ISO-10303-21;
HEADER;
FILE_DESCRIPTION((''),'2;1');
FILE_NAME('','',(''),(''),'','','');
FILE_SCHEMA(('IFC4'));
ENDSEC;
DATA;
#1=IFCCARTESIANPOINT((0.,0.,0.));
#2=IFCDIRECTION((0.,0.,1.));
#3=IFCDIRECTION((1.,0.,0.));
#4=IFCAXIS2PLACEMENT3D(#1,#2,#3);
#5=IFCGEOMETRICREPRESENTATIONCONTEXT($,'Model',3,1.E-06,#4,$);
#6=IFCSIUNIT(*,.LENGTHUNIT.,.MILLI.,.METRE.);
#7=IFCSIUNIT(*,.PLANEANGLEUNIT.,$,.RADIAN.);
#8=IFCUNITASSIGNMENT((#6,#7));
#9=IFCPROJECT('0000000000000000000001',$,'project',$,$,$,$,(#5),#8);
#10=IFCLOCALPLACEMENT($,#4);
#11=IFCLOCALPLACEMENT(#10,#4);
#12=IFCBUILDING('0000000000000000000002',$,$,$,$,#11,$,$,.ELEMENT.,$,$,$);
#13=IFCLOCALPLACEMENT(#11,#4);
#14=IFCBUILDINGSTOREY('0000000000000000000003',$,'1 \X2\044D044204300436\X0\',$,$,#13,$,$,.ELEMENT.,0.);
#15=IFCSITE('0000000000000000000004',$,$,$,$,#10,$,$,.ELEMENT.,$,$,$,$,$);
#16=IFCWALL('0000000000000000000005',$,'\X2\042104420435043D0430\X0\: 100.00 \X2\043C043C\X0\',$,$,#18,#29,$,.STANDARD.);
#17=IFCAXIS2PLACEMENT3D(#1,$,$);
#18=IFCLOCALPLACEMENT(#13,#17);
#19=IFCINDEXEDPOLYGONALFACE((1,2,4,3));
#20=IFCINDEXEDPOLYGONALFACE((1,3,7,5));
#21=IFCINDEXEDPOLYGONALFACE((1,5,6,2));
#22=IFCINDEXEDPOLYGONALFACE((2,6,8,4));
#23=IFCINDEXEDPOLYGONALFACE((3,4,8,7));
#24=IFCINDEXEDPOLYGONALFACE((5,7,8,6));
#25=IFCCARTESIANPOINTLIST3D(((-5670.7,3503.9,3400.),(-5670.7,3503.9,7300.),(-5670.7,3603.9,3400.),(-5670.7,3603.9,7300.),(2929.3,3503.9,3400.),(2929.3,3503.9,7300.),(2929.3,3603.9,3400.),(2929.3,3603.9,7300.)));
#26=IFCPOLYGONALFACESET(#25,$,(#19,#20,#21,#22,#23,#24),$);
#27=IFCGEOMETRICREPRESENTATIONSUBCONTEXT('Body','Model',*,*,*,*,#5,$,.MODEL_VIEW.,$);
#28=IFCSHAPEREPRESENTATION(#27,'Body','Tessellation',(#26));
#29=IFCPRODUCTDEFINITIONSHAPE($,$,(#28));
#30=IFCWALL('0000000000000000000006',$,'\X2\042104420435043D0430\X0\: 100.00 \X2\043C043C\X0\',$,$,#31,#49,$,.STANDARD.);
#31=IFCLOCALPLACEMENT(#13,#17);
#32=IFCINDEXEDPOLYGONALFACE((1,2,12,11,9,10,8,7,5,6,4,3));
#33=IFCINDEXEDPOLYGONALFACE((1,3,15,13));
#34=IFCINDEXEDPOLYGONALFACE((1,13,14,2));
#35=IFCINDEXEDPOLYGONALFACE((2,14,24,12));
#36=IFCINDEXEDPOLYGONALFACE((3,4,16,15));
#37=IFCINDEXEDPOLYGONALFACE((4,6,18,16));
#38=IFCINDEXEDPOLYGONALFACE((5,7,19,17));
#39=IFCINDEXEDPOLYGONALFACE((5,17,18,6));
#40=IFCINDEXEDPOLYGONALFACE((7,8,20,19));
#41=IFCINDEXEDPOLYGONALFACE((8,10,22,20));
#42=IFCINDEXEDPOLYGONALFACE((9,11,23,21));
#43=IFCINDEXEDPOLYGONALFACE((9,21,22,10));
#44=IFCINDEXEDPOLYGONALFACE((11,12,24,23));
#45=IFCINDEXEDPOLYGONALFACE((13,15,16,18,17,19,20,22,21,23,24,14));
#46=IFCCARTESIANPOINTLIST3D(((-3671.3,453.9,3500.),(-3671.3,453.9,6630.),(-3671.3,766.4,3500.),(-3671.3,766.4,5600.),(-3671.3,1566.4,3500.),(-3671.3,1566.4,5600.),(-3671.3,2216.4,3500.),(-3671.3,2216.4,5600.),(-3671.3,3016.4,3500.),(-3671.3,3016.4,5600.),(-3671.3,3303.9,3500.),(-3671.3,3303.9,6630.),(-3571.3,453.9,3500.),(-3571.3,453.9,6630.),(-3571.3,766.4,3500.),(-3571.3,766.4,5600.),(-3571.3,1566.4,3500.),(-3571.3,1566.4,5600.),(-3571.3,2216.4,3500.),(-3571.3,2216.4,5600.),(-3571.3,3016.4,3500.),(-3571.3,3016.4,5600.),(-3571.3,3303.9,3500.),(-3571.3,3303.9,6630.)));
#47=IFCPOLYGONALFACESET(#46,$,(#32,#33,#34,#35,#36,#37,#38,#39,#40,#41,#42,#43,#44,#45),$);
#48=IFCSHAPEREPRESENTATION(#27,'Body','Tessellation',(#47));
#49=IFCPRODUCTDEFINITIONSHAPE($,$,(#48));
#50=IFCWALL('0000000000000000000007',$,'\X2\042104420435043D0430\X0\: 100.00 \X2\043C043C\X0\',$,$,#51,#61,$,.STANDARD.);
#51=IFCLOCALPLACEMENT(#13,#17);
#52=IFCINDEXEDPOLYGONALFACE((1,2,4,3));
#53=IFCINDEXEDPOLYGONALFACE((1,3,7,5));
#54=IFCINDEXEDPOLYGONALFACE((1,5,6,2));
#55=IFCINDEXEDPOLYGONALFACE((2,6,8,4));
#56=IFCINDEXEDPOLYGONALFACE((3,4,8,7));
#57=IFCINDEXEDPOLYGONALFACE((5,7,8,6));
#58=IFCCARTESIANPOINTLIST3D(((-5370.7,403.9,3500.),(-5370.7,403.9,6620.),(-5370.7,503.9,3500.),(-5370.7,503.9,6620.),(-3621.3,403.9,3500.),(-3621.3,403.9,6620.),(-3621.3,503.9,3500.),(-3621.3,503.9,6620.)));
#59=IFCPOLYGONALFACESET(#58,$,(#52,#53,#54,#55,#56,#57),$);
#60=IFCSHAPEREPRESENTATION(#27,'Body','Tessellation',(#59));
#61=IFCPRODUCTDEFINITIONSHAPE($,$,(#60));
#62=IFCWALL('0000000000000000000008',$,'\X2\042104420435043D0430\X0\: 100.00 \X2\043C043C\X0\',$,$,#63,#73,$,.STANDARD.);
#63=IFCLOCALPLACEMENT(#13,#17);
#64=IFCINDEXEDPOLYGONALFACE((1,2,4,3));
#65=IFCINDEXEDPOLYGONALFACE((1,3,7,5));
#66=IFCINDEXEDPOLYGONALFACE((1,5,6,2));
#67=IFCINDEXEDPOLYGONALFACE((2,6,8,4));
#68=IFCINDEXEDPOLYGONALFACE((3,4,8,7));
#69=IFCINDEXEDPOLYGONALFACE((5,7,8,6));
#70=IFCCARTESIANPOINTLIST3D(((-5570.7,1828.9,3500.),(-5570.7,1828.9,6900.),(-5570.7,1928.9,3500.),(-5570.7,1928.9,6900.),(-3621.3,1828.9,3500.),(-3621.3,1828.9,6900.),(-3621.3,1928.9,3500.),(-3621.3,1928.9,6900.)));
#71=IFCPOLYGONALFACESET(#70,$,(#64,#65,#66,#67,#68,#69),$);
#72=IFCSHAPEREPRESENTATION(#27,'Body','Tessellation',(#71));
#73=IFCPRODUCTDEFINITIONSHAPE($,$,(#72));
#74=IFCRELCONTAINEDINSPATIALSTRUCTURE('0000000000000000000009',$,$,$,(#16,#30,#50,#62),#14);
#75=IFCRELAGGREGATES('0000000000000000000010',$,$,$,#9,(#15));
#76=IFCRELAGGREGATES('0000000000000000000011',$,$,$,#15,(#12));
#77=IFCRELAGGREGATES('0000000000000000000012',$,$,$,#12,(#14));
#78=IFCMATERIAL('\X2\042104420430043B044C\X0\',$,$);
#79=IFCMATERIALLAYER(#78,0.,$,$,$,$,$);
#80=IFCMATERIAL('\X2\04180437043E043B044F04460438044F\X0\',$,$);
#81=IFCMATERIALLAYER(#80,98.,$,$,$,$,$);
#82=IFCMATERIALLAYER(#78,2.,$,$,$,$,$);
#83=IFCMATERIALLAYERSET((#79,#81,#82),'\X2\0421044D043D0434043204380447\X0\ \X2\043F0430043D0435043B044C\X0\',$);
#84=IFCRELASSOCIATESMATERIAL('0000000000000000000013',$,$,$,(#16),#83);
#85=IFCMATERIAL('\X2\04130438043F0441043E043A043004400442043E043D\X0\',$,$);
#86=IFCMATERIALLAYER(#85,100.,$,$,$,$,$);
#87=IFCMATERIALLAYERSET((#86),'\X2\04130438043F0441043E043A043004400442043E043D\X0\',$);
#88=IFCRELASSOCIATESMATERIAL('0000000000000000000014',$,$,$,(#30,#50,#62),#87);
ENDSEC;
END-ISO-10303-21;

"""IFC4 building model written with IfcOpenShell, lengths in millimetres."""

from ifc_helpers import new_model, si_unit, frame, origin_with_axes, place, context, subcontext, project, spatial, line, indexed_curve, outline, extrude, material, layer, layer_set, layer_usage, element, save


model = new_model("IFC4")

# Units and contexts
model_context = context("Model", 3, precision=1e-06, world=origin_with_axes())
body_context = subcontext(model_context, "Body", "Model", "MODEL_VIEW")
ifc_project = project(units=[si_unit("LENGTHUNIT", "METRE", prefix="MILLI"), si_unit("PLANEANGLEUNIT", "RADIAN")], contexts=[model_context])

# Site, building, storey
site_placement = place(None, origin_with_axes())
site = spatial("IfcSite", under=ifc_project, at=site_placement, CompositionType="ELEMENT")
building_placement = place(site_placement, origin_with_axes())
building = spatial("IfcBuilding", under=site, at=building_placement, CompositionType="ELEMENT")
storey_placement = place(building_placement, origin_with_axes())
storey = spatial("IfcBuildingStorey", under=building, at=storey_placement, Name="1 этаж", CompositionType="ELEMENT", Elevation=0.0)

# Wall
ifc_material_1 = material(Name="Сталь")
ifc_layer_1 = layer(ifc_material_1, 0.0)
ifc_material_2 = material(Name="Изоляция")
ifc_layer_2 = layer(ifc_material_2, 98.0)
ifc_layer_3 = layer(ifc_material_1, 2.0)
ifc_layer_set_1 = layer_set([ifc_layer_1, ifc_layer_2, ifc_layer_3], Name="Сэндвич панель")
ifc_layer_usage_1 = layer_usage(ifc_layer_set_1, "AXIS2", "NEGATIVE", 100.0)
wall_1_placement = place(storey_placement, frame((-5670.7, 3503.9, 3400.0), z_axis=(0.0, 0.0, 1.0), x_axis=(1.0, 0.0, 0.0)))
element("IfcWall", 1, at=wall_1_placement, inside=storey, material=ifc_layer_usage_1, Name="Стена: 100.00 мм", PredefinedType="STANDARD", context=body_context, shape_type="SweptSolid", body=[
    extrude(outline(indexed_curve([(0.0, 0.0), (8600.0, 0.0), (8600.0, 100.0), (0.0, 100.0)], segments=[line(1, 2), line(2, 3), line(3, 4), line(4, 1)])), origin_with_axes(), (0.0, 0.0, 1.0), 3900.0),
])

# Wall, openings
ifc_material_3 = material(Name="Гипсокартон")
ifc_layer_4 = layer(ifc_material_3, 100.0)
ifc_layer_set_2 = layer_set([ifc_layer_4], Name="Гипсокартон")
ifc_layer_usage_2 = layer_usage(ifc_layer_set_2, "AXIS2", "NEGATIVE", 50.0)
wall_2_placement = place(storey_placement, frame((-3621.3, 3303.9, 3500.0), z_axis=(0.0, 0.0, 1.0), x_axis=(0.0, -1.0, 0.0)))
wall_2 = element("IfcWall", 2, at=wall_2_placement, inside=storey, material=ifc_layer_usage_2, Name="Стена: 100.00 мм", PredefinedType="STANDARD", context=body_context, shape_type="SweptSolid", body=[
    extrude(outline(indexed_curve([(0.0, -50.0), (2850.0, -50.0), (2850.0, 50.0), (0.0, 50.0)], segments=[line(1, 2), line(2, 3), line(3, 4), line(4, 1)])), origin_with_axes(), (0.0, 0.0, 1.0), 3130.0),
])
opening_1_placement = place(wall_2_placement, frame((1087.5, 50.0, 0.0), z_axis=(0.0, 0.0, 1.0), x_axis=(-1.0, 0.0, 0.0)))
element("IfcOpeningElement", 3, at=opening_1_placement, cuts=wall_2, PredefinedType="OPENING", context=body_context, shape_type="SweptSolid", body=[
    extrude(outline(indexed_curve([(0.0, 0.0), (800.0, 0.0), (800.0, 2100.0), (0.0, 2100.0)], segments=[line(1, 2), line(2, 3), line(3, 4), line(4, 1)])), frame((0.0, -5.0, 0.0), z_axis=(0.0, -1.0, 0.0), x_axis=(1.0, 0.0, 0.0)), (0.0, 0.0, -1.0), 110.0),
])
opening_2_placement = place(wall_2_placement, frame((2537.5, 50.0, 0.0), z_axis=(0.0, 0.0, 1.0), x_axis=(-1.0, 0.0, 0.0)))
element("IfcOpeningElement", 4, at=opening_2_placement, cuts=wall_2, PredefinedType="OPENING", context=body_context, shape_type="SweptSolid", body=[
    extrude(outline(indexed_curve([(0.0, 0.0), (800.0, 0.0), (800.0, 2100.0), (0.0, 2100.0)], segments=[line(1, 2), line(2, 3), line(3, 4), line(4, 1)])), frame((0.0, -5.0, 0.0), z_axis=(0.0, -1.0, 0.0), x_axis=(1.0, 0.0, 0.0)), (0.0, 0.0, -1.0), 110.0),
])

# Walls
wall_3_placement = place(storey_placement, frame((-3621.3, 453.9, 3500.0), z_axis=(0.0, 0.0, 1.0), x_axis=(-1.0, 0.0, 0.0)))
element("IfcWall", 5, at=wall_3_placement, inside=storey, material=ifc_layer_usage_2, Name="Стена: 100.00 мм", PredefinedType="STANDARD", context=body_context, shape_type="SweptSolid", body=[
    extrude(outline(indexed_curve([(0.0, -50.0), (1749.4, -50.0), (1749.4, 50.0), (0.0, 50.0)], segments=[line(1, 2), line(2, 3), line(3, 4), line(4, 1)])), origin_with_axes(), (0.0, 0.0, 1.0), 3120.0),
])
wall_4_placement = place(storey_placement, frame((-3621.3, 1878.9, 3500.0), z_axis=(0.0, 0.0, 1.0), x_axis=(-1.0, 0.0, 0.0)))
element("IfcWall", 6, at=wall_4_placement, inside=storey, material=ifc_layer_usage_2, Name="Стена: 100.00 мм", PredefinedType="STANDARD", context=body_context, shape_type="SweptSolid", body=[
    extrude(outline(indexed_curve([(0.0, -50.0), (1949.4, -50.0), (1949.4, 50.0), (0.0, 50.0)], segments=[line(1, 2), line(2, 3), line(3, 4), line(4, 1)])), origin_with_axes(), (0.0, 0.0, 1.0), 3400.0),
])

save(model, "model.ifc")
